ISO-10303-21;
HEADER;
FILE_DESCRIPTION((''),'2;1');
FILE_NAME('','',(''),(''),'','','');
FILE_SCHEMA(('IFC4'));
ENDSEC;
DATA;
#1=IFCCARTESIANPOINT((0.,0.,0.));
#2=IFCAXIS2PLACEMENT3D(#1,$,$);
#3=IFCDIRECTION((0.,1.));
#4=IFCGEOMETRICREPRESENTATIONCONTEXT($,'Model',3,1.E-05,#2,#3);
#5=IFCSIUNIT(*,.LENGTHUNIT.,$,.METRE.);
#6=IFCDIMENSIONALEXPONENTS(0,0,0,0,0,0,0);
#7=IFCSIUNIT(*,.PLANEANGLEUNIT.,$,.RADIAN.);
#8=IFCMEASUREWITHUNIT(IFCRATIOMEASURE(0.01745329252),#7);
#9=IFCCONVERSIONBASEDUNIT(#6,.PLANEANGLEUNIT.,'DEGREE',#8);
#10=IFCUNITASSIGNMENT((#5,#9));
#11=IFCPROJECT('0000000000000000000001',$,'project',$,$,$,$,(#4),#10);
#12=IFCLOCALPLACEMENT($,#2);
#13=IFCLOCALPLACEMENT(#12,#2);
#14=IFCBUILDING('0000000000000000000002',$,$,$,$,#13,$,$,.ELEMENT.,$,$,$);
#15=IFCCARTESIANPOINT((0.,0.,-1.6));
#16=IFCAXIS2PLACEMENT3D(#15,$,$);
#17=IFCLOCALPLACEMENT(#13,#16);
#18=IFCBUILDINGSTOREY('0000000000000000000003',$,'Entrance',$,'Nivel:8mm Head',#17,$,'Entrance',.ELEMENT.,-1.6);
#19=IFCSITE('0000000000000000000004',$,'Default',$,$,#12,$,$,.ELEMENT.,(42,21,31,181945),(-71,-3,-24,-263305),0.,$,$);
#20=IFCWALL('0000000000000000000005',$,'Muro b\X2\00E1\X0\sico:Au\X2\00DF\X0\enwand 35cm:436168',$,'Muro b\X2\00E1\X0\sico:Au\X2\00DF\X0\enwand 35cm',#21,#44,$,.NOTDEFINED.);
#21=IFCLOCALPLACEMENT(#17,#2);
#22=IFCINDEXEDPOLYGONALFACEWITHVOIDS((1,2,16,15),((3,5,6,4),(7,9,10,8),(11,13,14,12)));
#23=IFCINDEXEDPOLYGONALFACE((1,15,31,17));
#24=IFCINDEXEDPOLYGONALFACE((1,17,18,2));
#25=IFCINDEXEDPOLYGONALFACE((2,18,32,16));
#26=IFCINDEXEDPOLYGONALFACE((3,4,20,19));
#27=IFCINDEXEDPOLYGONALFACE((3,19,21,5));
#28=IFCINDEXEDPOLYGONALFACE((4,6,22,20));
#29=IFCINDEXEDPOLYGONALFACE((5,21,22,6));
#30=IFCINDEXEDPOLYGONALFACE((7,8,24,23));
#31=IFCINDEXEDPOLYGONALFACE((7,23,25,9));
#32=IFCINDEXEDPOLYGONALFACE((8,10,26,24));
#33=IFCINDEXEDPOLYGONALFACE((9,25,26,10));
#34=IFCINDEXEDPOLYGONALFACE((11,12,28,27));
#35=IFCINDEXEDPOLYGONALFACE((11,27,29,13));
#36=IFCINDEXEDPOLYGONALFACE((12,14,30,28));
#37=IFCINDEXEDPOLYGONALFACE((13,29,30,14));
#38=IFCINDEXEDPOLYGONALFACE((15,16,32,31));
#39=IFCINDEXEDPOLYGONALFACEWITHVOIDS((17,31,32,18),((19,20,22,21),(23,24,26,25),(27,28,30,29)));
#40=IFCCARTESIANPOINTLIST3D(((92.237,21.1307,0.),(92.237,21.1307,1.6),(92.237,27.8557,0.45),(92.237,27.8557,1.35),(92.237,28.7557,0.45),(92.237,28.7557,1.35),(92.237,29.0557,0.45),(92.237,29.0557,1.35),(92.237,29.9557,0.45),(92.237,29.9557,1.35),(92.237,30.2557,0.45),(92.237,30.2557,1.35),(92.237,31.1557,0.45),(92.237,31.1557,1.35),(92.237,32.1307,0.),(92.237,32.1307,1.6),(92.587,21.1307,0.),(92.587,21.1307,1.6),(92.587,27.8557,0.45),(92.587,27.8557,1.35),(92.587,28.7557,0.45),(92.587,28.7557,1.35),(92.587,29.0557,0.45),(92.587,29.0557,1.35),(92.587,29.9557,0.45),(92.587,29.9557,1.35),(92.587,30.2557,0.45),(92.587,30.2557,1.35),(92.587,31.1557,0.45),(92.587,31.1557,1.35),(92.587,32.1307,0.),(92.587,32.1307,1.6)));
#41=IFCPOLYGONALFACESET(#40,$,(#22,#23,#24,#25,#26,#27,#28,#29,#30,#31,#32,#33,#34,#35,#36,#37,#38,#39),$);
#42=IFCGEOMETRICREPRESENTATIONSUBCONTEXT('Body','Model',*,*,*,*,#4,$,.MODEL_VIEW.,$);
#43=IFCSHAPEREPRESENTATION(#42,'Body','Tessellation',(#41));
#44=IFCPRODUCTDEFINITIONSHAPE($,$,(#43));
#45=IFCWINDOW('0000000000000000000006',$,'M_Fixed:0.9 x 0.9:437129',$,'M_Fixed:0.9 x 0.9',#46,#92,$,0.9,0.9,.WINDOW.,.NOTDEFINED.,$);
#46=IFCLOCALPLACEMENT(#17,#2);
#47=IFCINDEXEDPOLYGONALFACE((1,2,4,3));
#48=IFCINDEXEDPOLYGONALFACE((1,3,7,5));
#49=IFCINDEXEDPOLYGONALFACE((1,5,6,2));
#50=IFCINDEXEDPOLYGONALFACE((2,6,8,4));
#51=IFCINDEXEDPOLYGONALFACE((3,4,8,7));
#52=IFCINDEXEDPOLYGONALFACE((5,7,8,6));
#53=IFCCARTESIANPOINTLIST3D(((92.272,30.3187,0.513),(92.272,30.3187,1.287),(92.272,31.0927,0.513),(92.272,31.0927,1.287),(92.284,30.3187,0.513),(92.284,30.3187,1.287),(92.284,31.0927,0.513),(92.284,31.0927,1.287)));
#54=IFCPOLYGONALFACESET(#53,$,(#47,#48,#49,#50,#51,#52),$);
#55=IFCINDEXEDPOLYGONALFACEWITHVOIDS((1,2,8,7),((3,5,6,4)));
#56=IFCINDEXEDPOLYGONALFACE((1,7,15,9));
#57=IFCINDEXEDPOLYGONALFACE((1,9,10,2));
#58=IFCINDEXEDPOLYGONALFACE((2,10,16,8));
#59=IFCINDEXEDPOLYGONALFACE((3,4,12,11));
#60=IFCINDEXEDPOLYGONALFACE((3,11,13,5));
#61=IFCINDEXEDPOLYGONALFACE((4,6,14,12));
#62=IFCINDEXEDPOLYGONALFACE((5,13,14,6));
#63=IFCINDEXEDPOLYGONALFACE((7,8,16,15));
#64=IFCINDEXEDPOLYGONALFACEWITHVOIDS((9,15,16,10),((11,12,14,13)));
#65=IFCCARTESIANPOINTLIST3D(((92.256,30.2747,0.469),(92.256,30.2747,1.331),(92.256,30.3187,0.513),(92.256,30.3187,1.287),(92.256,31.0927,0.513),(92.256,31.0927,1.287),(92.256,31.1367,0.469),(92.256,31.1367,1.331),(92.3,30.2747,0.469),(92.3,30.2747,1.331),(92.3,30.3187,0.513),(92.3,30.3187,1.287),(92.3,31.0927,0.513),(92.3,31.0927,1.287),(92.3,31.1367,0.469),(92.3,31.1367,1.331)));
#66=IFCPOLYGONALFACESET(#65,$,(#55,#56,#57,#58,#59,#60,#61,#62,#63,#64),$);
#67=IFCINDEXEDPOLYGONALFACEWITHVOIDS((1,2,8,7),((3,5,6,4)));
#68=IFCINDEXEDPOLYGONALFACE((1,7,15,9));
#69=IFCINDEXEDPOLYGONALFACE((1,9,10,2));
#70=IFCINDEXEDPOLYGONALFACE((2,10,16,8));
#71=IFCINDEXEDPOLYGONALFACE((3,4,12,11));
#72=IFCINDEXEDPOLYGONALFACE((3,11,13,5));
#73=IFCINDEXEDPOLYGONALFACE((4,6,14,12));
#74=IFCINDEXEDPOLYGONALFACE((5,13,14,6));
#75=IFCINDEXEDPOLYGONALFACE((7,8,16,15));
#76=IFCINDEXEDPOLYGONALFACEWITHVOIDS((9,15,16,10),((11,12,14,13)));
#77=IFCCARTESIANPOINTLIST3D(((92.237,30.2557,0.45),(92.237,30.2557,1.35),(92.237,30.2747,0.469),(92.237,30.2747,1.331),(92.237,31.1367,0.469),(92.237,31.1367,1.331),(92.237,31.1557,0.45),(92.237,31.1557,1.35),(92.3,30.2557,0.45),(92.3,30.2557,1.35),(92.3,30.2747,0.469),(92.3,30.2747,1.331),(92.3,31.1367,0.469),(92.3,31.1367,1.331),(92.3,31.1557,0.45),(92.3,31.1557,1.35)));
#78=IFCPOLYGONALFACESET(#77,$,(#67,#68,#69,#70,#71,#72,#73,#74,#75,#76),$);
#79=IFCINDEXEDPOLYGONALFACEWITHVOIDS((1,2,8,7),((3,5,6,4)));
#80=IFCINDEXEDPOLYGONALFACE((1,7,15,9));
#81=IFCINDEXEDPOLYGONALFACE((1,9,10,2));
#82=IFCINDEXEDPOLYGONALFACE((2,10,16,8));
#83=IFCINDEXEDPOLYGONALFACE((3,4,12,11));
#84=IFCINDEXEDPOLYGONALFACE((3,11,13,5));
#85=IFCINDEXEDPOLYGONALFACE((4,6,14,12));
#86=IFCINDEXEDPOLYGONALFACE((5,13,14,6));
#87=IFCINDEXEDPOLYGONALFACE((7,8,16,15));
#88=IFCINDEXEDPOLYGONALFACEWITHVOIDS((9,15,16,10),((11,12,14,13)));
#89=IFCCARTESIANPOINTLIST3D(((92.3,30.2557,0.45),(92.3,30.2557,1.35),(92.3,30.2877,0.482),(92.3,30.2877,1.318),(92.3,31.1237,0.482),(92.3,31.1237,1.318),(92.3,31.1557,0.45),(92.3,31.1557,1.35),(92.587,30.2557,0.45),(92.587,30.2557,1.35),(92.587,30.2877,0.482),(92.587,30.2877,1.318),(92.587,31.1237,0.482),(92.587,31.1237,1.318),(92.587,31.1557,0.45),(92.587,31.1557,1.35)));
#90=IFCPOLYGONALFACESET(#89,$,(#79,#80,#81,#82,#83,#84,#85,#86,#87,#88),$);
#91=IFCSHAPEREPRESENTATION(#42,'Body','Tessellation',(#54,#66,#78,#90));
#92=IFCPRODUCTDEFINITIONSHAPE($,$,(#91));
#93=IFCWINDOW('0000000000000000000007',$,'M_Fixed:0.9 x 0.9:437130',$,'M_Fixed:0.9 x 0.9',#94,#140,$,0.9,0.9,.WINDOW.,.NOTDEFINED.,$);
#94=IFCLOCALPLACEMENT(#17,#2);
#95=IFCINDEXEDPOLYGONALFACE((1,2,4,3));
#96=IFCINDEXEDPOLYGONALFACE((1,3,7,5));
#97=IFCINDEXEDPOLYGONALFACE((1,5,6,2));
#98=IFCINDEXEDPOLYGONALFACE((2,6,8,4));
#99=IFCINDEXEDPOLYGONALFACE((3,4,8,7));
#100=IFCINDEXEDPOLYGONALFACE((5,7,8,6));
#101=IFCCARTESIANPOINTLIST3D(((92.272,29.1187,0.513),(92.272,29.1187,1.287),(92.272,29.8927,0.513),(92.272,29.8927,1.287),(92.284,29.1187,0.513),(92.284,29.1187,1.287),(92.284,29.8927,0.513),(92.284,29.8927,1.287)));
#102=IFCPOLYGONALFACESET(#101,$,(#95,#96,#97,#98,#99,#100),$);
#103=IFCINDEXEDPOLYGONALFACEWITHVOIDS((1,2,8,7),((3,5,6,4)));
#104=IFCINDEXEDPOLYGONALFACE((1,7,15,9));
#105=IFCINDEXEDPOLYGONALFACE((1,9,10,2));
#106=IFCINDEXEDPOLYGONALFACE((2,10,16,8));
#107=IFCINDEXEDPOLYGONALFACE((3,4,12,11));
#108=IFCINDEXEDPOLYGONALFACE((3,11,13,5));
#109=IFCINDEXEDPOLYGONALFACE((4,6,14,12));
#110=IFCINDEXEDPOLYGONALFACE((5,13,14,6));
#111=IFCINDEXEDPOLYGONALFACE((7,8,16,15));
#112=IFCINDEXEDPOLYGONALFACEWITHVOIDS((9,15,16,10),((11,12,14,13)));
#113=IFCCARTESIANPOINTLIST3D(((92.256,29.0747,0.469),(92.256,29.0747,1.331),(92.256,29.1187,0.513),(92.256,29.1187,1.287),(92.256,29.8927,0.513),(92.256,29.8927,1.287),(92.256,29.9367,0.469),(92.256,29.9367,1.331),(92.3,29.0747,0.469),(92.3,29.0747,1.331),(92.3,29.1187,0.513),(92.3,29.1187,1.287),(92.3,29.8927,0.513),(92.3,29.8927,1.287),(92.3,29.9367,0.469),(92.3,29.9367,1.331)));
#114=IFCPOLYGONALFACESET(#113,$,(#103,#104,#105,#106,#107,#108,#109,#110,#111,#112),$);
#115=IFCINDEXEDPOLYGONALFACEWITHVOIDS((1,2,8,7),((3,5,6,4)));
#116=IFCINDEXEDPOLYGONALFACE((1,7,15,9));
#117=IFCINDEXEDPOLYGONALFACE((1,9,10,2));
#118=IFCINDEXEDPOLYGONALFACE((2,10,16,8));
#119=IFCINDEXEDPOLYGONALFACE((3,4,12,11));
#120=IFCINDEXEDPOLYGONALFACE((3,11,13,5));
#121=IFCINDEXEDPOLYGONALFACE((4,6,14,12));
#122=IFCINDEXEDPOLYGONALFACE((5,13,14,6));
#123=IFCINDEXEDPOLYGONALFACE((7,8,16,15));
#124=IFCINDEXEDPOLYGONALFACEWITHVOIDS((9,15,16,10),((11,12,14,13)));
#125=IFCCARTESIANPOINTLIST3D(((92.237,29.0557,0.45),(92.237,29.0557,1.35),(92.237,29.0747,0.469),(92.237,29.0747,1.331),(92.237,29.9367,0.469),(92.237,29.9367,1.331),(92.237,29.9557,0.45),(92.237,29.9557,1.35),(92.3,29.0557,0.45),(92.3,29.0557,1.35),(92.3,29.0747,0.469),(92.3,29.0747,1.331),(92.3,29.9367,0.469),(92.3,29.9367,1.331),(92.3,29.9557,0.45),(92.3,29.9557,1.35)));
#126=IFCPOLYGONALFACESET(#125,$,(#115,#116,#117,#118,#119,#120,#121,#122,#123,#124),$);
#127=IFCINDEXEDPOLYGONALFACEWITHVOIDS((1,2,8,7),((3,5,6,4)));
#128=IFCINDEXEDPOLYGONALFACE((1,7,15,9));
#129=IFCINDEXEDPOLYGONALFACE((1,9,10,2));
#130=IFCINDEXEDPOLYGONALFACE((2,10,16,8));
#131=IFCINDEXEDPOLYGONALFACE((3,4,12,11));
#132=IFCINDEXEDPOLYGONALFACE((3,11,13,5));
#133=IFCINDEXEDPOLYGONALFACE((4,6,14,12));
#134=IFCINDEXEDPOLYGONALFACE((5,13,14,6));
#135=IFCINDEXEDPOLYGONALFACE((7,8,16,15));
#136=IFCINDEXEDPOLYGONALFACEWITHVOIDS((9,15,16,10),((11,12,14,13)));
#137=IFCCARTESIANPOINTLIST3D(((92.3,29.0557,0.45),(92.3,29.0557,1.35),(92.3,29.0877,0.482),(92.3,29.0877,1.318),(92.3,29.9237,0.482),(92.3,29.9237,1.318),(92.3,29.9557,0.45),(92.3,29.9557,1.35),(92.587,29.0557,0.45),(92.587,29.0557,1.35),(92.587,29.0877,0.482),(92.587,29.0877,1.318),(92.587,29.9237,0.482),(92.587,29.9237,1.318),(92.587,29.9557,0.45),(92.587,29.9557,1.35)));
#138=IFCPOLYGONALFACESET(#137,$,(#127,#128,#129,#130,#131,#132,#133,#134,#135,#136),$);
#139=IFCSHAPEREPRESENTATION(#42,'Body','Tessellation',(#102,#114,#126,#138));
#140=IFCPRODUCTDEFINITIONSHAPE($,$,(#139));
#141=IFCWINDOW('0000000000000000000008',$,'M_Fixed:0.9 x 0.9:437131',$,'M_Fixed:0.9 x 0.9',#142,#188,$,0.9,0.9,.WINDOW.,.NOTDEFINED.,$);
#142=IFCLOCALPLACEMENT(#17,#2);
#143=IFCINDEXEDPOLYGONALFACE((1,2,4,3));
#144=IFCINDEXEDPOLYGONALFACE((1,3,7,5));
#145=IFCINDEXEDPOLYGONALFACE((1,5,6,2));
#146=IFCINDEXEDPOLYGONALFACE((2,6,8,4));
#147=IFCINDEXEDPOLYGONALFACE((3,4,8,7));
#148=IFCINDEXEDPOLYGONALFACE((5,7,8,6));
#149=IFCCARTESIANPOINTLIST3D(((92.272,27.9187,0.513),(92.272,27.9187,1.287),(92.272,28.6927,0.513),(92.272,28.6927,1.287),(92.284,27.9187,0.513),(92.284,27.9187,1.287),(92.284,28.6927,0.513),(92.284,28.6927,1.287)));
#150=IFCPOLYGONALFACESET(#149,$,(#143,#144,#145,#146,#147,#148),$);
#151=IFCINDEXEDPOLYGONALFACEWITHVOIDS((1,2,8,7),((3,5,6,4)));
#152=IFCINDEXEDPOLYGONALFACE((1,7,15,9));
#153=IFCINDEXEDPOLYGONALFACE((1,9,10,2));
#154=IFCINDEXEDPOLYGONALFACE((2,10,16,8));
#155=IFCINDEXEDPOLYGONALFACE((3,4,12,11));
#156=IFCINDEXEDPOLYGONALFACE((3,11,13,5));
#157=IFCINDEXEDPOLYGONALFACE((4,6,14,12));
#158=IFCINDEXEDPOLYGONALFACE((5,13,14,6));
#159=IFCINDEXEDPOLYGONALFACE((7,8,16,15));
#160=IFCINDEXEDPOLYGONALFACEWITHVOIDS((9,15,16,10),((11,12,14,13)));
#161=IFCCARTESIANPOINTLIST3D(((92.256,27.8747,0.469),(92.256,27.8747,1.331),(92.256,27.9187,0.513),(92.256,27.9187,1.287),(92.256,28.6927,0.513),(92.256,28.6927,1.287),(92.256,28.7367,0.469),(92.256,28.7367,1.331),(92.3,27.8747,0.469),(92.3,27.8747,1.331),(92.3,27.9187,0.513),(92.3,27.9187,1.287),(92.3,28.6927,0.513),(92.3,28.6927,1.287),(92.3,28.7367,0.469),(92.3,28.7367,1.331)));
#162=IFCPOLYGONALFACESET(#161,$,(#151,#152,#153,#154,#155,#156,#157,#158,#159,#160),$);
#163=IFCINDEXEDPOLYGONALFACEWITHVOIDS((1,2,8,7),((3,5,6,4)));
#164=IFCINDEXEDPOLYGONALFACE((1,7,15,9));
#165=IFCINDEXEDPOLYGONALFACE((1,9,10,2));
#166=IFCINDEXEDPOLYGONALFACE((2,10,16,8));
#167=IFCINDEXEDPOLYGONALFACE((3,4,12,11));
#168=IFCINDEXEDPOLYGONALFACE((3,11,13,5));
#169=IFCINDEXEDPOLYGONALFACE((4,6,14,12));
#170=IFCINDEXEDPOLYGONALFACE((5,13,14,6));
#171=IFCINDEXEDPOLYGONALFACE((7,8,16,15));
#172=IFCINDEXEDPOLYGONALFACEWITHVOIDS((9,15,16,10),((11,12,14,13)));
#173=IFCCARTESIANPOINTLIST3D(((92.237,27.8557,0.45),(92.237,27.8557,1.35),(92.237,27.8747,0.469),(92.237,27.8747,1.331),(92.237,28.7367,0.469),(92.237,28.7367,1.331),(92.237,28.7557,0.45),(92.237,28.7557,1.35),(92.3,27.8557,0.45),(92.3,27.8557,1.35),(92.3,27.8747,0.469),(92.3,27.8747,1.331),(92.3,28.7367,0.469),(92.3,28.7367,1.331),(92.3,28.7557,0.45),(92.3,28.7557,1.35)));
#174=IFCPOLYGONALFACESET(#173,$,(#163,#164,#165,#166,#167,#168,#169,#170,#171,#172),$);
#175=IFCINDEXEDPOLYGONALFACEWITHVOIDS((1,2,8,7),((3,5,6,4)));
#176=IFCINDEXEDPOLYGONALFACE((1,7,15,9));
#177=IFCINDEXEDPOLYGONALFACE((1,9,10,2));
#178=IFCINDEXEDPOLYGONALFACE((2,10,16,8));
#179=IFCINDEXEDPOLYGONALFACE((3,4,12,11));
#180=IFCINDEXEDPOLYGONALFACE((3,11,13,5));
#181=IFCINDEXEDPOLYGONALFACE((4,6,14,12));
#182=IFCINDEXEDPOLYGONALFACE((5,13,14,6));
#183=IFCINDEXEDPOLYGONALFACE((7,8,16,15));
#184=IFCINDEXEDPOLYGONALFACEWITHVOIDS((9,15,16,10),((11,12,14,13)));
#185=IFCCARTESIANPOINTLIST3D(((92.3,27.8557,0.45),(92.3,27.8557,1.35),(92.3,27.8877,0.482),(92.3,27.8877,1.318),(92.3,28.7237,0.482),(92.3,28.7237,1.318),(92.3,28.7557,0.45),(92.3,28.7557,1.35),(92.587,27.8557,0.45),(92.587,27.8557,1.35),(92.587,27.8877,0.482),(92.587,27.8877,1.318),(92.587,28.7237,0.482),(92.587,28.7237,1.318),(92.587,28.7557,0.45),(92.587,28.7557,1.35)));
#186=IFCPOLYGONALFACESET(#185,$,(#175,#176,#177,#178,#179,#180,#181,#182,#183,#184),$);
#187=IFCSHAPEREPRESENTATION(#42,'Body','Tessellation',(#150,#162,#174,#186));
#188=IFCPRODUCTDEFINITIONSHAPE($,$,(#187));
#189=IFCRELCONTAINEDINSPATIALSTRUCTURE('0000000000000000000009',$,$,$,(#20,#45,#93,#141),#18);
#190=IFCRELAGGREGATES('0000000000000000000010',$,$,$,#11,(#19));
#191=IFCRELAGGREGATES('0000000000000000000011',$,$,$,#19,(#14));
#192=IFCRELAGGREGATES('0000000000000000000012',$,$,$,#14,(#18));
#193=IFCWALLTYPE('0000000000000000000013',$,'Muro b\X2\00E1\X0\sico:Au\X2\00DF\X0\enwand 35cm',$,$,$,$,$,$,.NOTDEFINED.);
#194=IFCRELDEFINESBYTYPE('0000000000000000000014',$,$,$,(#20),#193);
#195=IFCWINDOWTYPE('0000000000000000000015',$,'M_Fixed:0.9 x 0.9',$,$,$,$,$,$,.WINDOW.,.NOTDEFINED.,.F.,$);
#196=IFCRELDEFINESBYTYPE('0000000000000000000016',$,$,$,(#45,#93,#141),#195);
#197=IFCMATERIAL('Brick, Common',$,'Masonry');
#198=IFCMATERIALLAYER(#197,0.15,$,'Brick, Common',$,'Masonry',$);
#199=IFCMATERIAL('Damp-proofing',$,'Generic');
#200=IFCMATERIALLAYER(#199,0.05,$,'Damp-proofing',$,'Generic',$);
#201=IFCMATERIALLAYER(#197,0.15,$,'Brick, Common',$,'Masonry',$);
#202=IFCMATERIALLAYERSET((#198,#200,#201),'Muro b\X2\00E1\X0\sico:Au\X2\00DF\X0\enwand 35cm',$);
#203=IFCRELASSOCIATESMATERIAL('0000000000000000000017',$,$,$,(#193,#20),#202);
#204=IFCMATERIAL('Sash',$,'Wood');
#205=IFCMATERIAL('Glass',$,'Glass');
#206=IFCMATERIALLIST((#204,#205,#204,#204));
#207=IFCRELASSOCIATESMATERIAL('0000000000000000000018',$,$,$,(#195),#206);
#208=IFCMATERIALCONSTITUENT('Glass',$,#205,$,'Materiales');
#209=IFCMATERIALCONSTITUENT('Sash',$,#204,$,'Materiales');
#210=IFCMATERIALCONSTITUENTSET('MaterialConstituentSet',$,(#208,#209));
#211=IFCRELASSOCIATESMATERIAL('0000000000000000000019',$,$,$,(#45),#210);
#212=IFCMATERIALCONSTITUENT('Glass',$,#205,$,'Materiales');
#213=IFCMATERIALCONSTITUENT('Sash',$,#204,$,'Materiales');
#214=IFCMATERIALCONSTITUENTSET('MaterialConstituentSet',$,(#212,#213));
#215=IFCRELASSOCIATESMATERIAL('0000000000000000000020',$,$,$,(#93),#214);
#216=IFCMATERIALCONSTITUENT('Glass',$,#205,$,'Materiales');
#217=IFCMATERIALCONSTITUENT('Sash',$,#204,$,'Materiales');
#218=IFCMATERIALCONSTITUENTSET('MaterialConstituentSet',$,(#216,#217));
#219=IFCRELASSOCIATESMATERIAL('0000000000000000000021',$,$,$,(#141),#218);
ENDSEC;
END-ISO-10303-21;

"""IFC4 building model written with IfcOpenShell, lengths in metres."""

from ifc_helpers import new_model, entity, si_unit, converted_unit, direction, frame, frame_2d, origin, origin_2d_with_axis, place, context, subcontext, project, spatial, polyline, rectangle, outline, extrude, source, transform, mapped, material, material_list, layer, layer_set, layer_usage, constituent, constituent_set, type_object, type_shapes, element, fill, save


model = new_model("IFC4")

# Units and contexts
model_context = context("Model", 3, precision=1e-05, world=origin(), true_north=direction((0.0, 1.0)))
body_context = subcontext(model_context, "Body", "Model", "MODEL_VIEW")
ifc_project = project(units=[si_unit("LENGTHUNIT", "METRE"), converted_unit("PLANEANGLEUNIT", "DEGREE", entity("IfcRatioMeasure", 0.01745329252), si_unit("PLANEANGLEUNIT", "RADIAN"), dimensions=[0, 0, 0, 0, 0, 0, 0])], contexts=[model_context])

# Site, building, storey
site_placement = place(None, origin())
site = spatial("IfcSite", under=ifc_project, at=site_placement, Name="Default", CompositionType="ELEMENT", RefLatitude=(42, 21, 31, 181945), RefLongitude=(-71, -3, -24, -263305), RefElevation=0.0)
building_placement = place(site_placement, origin())
building = spatial("IfcBuilding", under=site, at=building_placement, CompositionType="ELEMENT")
storey_placement = place(building_placement, frame((0.0, 0.0, -1.6)))
storey = spatial("IfcBuildingStorey", under=building, at=storey_placement, Name="Entrance", ObjectType="Nivel:8mm Head", LongName="Entrance", CompositionType="ELEMENT", Elevation=-1.6)

# Wall, openings, windows
ifc_material_1 = material(Name="Brick, Common", Category="Masonry")
ifc_layer_1 = layer(ifc_material_1, 0.15, Name="Brick, Common", Category="Masonry")
ifc_material_2 = material(Name="Damp-proofing", Category="Generic")
ifc_layer_2 = layer(ifc_material_2, 0.05, Name="Damp-proofing", Category="Generic")
ifc_layer_3 = layer(ifc_material_1, 0.15, Name="Brick, Common", Category="Masonry")
ifc_layer_set_1 = layer_set([ifc_layer_1, ifc_layer_2, ifc_layer_3], Name="Muro básico:Außenwand 35cm")
ifc_layer_usage_1 = layer_usage(ifc_layer_set_1, "AXIS2", "NEGATIVE", 0.175)
wall_type = type_object("IfcWallType", Name="Muro básico:Außenwand 35cm", PredefinedType="NOTDEFINED", material=ifc_layer_set_1)
wall_1_placement = place(storey_placement, frame((92.412, 32.1307, 0.0), z_axis=(0.0, 0.0, 1.0), x_axis=(0.0, -1.0, 0.0)))
wall_1 = element("IfcWall", 1, at=wall_1_placement, inside=storey, type_object=wall_type, material=ifc_layer_usage_1, Name="Muro básico:Außenwand 35cm:436168", ObjectType="Muro básico:Außenwand 35cm", PredefinedType="NOTDEFINED", context=body_context, shape_type="SweptSolid", body=[
    extrude(rectangle(XDim=11.0, YDim=0.35, at=frame_2d((5.5, 0.0), x_axis=(-1.0, 0.0))), origin(), (0.0, 0.0, 1.0), 1.6),
])
opening_1_placement = place(wall_1_placement, frame((1.875, 0.175, 0.45)))
opening_1 = element("IfcOpeningElement", 2, at=opening_1_placement, cuts=wall_1, ObjectType="Opening", PredefinedType="OPENING", context=body_context, shape_type="SweptSolid", body=[
    extrude(rectangle(XDim=0.9, YDim=0.9, at=frame_2d((0.45, 0.45), x_axis=(1.0, 0.0))), frame((0.0, 0.0, 0.0), z_axis=(0.0, -1.0, 0.0), x_axis=(0.0, 0.0, 1.0)), (0.0, 0.0, 1.0), 0.35),
])
opening_2_placement = place(wall_1_placement, frame((3.075, 0.175, 0.45)))
opening_2 = element("IfcOpeningElement", 3, at=opening_2_placement, cuts=wall_1, ObjectType="Opening", PredefinedType="OPENING", context=body_context, shape_type="SweptSolid", body=[
    extrude(rectangle(XDim=0.9, YDim=0.9, at=frame_2d((0.45, 0.45), x_axis=(1.0, 0.0))), frame((0.0, 0.0, 0.0), z_axis=(0.0, -1.0, 0.0), x_axis=(0.0, 0.0, 1.0)), (0.0, 0.0, 1.0), 0.35),
])
opening_3_placement = place(wall_1_placement, frame((4.275, 0.175, 0.45)))
opening_3 = element("IfcOpeningElement", 4, at=opening_3_placement, cuts=wall_1, ObjectType="Opening", PredefinedType="OPENING", context=body_context, shape_type="SweptSolid", body=[
    extrude(rectangle(XDim=0.9, YDim=0.9, at=frame_2d((0.45, 0.45), x_axis=(1.0, 0.0))), frame((0.0, 0.0, 0.0), z_axis=(0.0, -1.0, 0.0), x_axis=(0.0, 0.0, 1.0)), (0.0, 0.0, 1.0), 0.35),
])
ifc_material_3 = material(Name="Glass", Category="Glass")
ifc_constituent_1 = constituent(ifc_material_3, Name="Glass", Category="Materiales")
ifc_material_4 = material(Name="Sash", Category="Wood")
ifc_constituent_2 = constituent(ifc_material_4, Name="Sash", Category="Materiales")
ifc_constituent_set_1 = constituent_set(constituents=[ifc_constituent_1, ifc_constituent_2], Name="MaterialConstituentSet")
ifc_material_list = material_list([ifc_material_4, ifc_material_3, ifc_material_4, ifc_material_4])
window_type = type_object("IfcWindowType", Name="M_Fixed:0.9 x 0.9", ParameterTakesPrecedence=False, PartitioningType="NOTDEFINED", PredefinedType="WINDOW", material=ifc_material_list)
shared_shape = source(origin(), body_context, "Body", "SweptSolid", [
    extrude(rectangle(XDim=0.012, YDim=0.774, at=origin_2d_with_axis()), frame((0.45, 0.309, 0.063), z_axis=(0.0, 0.0, 1.0), x_axis=(0.0, -1.0, 0.0)), (0.0, 0.0, 1.0), 0.774),
    extrude(outline(polyline([(-0.431, -0.431), (0.431, -0.431), (0.431, 0.431), (-0.431, 0.431), (-0.431, -0.431)]), holes=[polyline([(-0.387, -0.387), (-0.387, 0.387), (0.387, 0.387), (0.387, -0.387), (-0.387, -0.387)])]), frame((0.45, 0.287, 0.45), z_axis=(0.0, 1.0, 0.0), x_axis=(1.0, 0.0, 0.0)), (0.0, 0.0, 1.0), 0.044),
    extrude(outline(polyline([(-0.45, -0.45), (0.45, -0.45), (0.45, 0.45), (-0.45, 0.45), (-0.45, -0.45)]), holes=[polyline([(-0.431, -0.431), (-0.431, 0.431), (0.431, 0.431), (0.431, -0.431), (-0.431, -0.431)])]), frame((0.45, 0.287, 0.45), z_axis=(0.0, 1.0, 0.0), x_axis=(1.0, 0.0, 0.0)), (0.0, 0.0, 1.0), 0.063),
    extrude(outline(polyline([(-0.45, -0.45), (0.45, -0.45), (0.45, 0.45), (-0.45, 0.45), (-0.45, -0.45)]), holes=[polyline([(-0.418, -0.418), (-0.418, 0.418), (0.418, 0.418), (0.418, -0.418), (-0.418, -0.418)])]), frame((0.45, 0.0, 0.45), z_axis=(0.0, 1.0, 0.0), x_axis=(1.0, 0.0, 0.0)), (0.0, 0.0, 1.0), 0.287),
])
type_shapes(window_type, [shared_shape])
window_1_placement = place(opening_1_placement, frame((0.0, 0.0, 0.0), z_axis=(0.0, 0.0, 1.0), x_axis=(-1.0, 0.0, 0.0)))
window_1 = element("IfcWindow", 5, at=window_1_placement, inside=storey, type_object=window_type, material=ifc_constituent_set_1, Name="M_Fixed:0.9 x 0.9:437129", ObjectType="M_Fixed:0.9 x 0.9", OverallHeight=0.9, OverallWidth=0.9, PartitioningType="NOTDEFINED", PredefinedType="WINDOW", context=body_context, shape_type="MappedRepresentation", body=[
    mapped(shared_shape, transform((0.0, 0.0, 0.0), scale=1.0)),
])
fill(opening_1, window_1)
ifc_constituent_3 = constituent(ifc_material_3, Name="Glass", Category="Materiales")
ifc_constituent_4 = constituent(ifc_material_4, Name="Sash", Category="Materiales")
ifc_constituent_set_2 = constituent_set(constituents=[ifc_constituent_3, ifc_constituent_4], Name="MaterialConstituentSet")
window_2_placement = place(opening_2_placement, frame((0.0, 0.0, 0.0), z_axis=(0.0, 0.0, 1.0), x_axis=(-1.0, 0.0, 0.0)))
window_2 = element("IfcWindow", 6, at=window_2_placement, inside=storey, type_object=window_type, material=ifc_constituent_set_2, Name="M_Fixed:0.9 x 0.9:437130", ObjectType="M_Fixed:0.9 x 0.9", OverallHeight=0.9, OverallWidth=0.9, PartitioningType="NOTDEFINED", PredefinedType="WINDOW", context=body_context, shape_type="MappedRepresentation", body=[
    mapped(shared_shape, transform((0.0, 0.0, 0.0), scale=1.0)),
])
fill(opening_2, window_2)
ifc_constituent_5 = constituent(ifc_material_3, Name="Glass", Category="Materiales")
ifc_constituent_6 = constituent(ifc_material_4, Name="Sash", Category="Materiales")
ifc_constituent_set_3 = constituent_set(constituents=[ifc_constituent_5, ifc_constituent_6], Name="MaterialConstituentSet")
window_3_placement = place(opening_3_placement, frame((0.0, 0.0, 0.0), z_axis=(0.0, 0.0, 1.0), x_axis=(-1.0, 0.0, 0.0)))
window_3 = element("IfcWindow", 7, at=window_3_placement, inside=storey, type_object=window_type, material=ifc_constituent_set_3, Name="M_Fixed:0.9 x 0.9:437131", ObjectType="M_Fixed:0.9 x 0.9", OverallHeight=0.9, OverallWidth=0.9, PartitioningType="NOTDEFINED", PredefinedType="WINDOW", context=body_context, shape_type="MappedRepresentation", body=[
    mapped(shared_shape, transform((0.0, 0.0, 0.0), scale=1.0)),
])
fill(opening_3, window_3)

save(model, "model.ifc")
